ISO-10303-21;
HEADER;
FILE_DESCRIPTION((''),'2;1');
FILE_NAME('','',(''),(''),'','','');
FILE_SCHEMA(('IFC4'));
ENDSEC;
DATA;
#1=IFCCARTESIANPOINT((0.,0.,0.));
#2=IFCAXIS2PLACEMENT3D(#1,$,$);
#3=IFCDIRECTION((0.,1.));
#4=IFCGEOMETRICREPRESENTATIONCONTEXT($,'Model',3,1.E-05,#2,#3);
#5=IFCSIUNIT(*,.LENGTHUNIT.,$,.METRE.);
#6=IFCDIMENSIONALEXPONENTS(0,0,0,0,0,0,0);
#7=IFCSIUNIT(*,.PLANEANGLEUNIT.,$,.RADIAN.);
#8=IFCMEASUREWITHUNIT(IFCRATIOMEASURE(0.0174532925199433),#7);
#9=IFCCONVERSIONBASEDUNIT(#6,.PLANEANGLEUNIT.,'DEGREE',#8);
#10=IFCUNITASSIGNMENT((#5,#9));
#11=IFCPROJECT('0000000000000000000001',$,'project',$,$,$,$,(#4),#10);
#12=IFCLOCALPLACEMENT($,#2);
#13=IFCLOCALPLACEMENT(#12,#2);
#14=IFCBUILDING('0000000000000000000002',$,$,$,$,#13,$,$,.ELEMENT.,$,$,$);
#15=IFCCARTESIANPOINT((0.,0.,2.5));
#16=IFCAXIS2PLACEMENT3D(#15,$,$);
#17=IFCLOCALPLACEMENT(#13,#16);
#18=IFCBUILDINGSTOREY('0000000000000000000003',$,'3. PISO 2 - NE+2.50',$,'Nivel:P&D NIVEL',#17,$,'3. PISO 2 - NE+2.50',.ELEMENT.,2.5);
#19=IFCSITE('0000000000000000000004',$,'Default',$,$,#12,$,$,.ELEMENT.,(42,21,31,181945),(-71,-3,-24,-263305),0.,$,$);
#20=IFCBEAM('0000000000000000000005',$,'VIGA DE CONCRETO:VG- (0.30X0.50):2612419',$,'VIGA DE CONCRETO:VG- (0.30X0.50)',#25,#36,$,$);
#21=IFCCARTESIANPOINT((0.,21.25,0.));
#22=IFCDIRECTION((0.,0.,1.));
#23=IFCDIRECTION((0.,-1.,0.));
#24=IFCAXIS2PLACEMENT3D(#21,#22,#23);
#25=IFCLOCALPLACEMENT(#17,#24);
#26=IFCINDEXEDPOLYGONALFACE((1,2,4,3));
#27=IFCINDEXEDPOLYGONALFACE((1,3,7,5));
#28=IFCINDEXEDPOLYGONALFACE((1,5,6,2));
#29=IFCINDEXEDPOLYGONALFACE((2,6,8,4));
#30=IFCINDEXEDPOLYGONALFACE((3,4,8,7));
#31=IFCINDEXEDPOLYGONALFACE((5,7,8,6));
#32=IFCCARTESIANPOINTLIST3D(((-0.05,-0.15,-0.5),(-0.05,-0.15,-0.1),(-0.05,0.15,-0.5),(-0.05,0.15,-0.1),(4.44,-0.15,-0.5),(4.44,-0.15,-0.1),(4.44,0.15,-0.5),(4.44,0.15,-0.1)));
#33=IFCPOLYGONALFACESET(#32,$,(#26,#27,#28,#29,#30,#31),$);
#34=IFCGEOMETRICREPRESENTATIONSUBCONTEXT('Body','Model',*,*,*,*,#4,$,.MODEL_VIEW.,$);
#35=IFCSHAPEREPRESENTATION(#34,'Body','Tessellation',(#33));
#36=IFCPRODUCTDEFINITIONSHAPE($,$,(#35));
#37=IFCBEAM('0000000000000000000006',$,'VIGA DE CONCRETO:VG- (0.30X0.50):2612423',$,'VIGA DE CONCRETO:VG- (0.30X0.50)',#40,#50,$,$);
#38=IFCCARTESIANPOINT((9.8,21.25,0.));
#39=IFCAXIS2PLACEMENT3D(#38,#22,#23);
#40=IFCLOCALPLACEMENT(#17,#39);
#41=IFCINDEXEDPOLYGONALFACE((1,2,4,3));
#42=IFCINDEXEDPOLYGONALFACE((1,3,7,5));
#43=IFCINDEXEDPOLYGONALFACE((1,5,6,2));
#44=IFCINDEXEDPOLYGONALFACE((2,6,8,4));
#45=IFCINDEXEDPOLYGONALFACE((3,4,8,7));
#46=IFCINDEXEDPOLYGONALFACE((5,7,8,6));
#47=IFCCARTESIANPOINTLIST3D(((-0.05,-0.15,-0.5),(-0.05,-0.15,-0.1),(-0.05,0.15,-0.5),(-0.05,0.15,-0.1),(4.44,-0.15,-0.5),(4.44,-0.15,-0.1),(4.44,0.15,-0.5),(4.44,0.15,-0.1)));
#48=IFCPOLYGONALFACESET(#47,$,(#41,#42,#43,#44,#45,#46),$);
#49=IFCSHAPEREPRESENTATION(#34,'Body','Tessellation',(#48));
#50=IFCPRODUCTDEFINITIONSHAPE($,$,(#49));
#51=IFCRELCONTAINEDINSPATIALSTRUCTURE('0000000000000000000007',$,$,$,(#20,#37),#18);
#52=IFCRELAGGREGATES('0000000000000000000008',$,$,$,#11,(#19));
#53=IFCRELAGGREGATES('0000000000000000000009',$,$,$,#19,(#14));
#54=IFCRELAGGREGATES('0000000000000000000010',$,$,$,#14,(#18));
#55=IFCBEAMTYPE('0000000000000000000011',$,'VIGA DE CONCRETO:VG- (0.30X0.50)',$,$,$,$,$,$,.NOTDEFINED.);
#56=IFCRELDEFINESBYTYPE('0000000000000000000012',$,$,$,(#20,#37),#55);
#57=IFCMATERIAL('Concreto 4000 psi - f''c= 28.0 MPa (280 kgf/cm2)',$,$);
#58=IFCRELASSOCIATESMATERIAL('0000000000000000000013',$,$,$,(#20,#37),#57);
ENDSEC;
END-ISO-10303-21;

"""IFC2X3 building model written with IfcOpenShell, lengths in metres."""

from ifc_helpers import new_model, entity, si_unit, converted_unit, direction, frame, frame_2d, origin, place, context, subcontext, project, spatial, rectangle, extrude, material, type_object, element, save


model = new_model("IFC2X3")

# Units and contexts
model_context = context("Model", 3, precision=1e-05, world=origin(), true_north=direction((0.0, 1.0)))
body_context = subcontext(model_context, "Body", "Model", "MODEL_VIEW")
ifc_project = project(units=[si_unit("LENGTHUNIT", "METRE"), converted_unit("PLANEANGLEUNIT", "DEGREE", entity("IfcRatioMeasure", 0.0174532925199433), si_unit("PLANEANGLEUNIT", "RADIAN"), dimensions=[0, 0, 0, 0, 0, 0, 0])], contexts=[model_context])

# Site, building, storey
site_placement = place(None, origin())
site = spatial("IfcSite", under=ifc_project, at=site_placement, Name="Default", CompositionType="ELEMENT", RefLatitude=(42, 21, 31, 181945), RefLongitude=(-71, -3, -24, -263305), RefElevation=0.0)
building_placement = place(site_placement, origin())
building = spatial("IfcBuilding", under=site, at=building_placement, CompositionType="ELEMENT")
storey_placement = place(building_placement, frame((0.0, 0.0, 2.5)))
storey = spatial("IfcBuildingStorey", under=building, at=storey_placement, Name="3. PISO 2 - NE+2.50", ObjectType="Nivel:P&D NIVEL", LongName="3. PISO 2 - NE+2.50", CompositionType="ELEMENT", Elevation=2.5)

# Beams
ifc_material = material(Name="Concreto 4000 psi - f'c= 28.0 MPa (280 kgf/cm2)")
beam_type_1 = type_object("IfcBeamType", Name="VIGA DE CONCRETO:VG- (0.30X0.50)", PredefinedType="NOTDEFINED")
beam_1_placement = place(storey_placement, frame((0.0, 21.25, 0.0), z_axis=(0.0, 0.0, 1.0), x_axis=(0.0, -1.0, 0.0)))
element("IfcBeam", 1, at=beam_1_placement, inside=storey, type_object=beam_type_1, material=ifc_material, Name="VIGA DE CONCRETO:VG- (0.30X0.50):2612419", ObjectType="VIGA DE CONCRETO:VG- (0.30X0.50)", context=body_context, shape_type="SweptSolid", body=[
    extrude(rectangle(XDim=0.4, YDim=0.3, at=frame_2d((0.0, 0.0), x_axis=(1.0, 0.0))), frame((-0.05, 0.0, -0.3), z_axis=(1.0, 0.0, 0.0), x_axis=(0.0, 0.0, -1.0)), (0.0, 0.0, 1.0), 4.49),
])
beam_2_placement = place(storey_placement, frame((9.8, 21.25, 0.0), z_axis=(0.0, 0.0, 1.0), x_axis=(0.0, -1.0, 0.0)))
element("IfcBeam", 2, at=beam_2_placement, inside=storey, type_object=beam_type_1, material=ifc_material, Name="VIGA DE CONCRETO:VG- (0.30X0.50):2612423", ObjectType="VIGA DE CONCRETO:VG- (0.30X0.50)", context=body_context, shape_type="SweptSolid", body=[
    extrude(rectangle(XDim=0.4, YDim=0.3, at=frame_2d((0.0, 0.0), x_axis=(1.0, 0.0))), frame((-0.05, 0.0, -0.3), z_axis=(1.0, 0.0, 0.0), x_axis=(0.0, 0.0, -1.0)), (0.0, 0.0, 1.0), 4.49),
])

save(model, "model.ifc")
